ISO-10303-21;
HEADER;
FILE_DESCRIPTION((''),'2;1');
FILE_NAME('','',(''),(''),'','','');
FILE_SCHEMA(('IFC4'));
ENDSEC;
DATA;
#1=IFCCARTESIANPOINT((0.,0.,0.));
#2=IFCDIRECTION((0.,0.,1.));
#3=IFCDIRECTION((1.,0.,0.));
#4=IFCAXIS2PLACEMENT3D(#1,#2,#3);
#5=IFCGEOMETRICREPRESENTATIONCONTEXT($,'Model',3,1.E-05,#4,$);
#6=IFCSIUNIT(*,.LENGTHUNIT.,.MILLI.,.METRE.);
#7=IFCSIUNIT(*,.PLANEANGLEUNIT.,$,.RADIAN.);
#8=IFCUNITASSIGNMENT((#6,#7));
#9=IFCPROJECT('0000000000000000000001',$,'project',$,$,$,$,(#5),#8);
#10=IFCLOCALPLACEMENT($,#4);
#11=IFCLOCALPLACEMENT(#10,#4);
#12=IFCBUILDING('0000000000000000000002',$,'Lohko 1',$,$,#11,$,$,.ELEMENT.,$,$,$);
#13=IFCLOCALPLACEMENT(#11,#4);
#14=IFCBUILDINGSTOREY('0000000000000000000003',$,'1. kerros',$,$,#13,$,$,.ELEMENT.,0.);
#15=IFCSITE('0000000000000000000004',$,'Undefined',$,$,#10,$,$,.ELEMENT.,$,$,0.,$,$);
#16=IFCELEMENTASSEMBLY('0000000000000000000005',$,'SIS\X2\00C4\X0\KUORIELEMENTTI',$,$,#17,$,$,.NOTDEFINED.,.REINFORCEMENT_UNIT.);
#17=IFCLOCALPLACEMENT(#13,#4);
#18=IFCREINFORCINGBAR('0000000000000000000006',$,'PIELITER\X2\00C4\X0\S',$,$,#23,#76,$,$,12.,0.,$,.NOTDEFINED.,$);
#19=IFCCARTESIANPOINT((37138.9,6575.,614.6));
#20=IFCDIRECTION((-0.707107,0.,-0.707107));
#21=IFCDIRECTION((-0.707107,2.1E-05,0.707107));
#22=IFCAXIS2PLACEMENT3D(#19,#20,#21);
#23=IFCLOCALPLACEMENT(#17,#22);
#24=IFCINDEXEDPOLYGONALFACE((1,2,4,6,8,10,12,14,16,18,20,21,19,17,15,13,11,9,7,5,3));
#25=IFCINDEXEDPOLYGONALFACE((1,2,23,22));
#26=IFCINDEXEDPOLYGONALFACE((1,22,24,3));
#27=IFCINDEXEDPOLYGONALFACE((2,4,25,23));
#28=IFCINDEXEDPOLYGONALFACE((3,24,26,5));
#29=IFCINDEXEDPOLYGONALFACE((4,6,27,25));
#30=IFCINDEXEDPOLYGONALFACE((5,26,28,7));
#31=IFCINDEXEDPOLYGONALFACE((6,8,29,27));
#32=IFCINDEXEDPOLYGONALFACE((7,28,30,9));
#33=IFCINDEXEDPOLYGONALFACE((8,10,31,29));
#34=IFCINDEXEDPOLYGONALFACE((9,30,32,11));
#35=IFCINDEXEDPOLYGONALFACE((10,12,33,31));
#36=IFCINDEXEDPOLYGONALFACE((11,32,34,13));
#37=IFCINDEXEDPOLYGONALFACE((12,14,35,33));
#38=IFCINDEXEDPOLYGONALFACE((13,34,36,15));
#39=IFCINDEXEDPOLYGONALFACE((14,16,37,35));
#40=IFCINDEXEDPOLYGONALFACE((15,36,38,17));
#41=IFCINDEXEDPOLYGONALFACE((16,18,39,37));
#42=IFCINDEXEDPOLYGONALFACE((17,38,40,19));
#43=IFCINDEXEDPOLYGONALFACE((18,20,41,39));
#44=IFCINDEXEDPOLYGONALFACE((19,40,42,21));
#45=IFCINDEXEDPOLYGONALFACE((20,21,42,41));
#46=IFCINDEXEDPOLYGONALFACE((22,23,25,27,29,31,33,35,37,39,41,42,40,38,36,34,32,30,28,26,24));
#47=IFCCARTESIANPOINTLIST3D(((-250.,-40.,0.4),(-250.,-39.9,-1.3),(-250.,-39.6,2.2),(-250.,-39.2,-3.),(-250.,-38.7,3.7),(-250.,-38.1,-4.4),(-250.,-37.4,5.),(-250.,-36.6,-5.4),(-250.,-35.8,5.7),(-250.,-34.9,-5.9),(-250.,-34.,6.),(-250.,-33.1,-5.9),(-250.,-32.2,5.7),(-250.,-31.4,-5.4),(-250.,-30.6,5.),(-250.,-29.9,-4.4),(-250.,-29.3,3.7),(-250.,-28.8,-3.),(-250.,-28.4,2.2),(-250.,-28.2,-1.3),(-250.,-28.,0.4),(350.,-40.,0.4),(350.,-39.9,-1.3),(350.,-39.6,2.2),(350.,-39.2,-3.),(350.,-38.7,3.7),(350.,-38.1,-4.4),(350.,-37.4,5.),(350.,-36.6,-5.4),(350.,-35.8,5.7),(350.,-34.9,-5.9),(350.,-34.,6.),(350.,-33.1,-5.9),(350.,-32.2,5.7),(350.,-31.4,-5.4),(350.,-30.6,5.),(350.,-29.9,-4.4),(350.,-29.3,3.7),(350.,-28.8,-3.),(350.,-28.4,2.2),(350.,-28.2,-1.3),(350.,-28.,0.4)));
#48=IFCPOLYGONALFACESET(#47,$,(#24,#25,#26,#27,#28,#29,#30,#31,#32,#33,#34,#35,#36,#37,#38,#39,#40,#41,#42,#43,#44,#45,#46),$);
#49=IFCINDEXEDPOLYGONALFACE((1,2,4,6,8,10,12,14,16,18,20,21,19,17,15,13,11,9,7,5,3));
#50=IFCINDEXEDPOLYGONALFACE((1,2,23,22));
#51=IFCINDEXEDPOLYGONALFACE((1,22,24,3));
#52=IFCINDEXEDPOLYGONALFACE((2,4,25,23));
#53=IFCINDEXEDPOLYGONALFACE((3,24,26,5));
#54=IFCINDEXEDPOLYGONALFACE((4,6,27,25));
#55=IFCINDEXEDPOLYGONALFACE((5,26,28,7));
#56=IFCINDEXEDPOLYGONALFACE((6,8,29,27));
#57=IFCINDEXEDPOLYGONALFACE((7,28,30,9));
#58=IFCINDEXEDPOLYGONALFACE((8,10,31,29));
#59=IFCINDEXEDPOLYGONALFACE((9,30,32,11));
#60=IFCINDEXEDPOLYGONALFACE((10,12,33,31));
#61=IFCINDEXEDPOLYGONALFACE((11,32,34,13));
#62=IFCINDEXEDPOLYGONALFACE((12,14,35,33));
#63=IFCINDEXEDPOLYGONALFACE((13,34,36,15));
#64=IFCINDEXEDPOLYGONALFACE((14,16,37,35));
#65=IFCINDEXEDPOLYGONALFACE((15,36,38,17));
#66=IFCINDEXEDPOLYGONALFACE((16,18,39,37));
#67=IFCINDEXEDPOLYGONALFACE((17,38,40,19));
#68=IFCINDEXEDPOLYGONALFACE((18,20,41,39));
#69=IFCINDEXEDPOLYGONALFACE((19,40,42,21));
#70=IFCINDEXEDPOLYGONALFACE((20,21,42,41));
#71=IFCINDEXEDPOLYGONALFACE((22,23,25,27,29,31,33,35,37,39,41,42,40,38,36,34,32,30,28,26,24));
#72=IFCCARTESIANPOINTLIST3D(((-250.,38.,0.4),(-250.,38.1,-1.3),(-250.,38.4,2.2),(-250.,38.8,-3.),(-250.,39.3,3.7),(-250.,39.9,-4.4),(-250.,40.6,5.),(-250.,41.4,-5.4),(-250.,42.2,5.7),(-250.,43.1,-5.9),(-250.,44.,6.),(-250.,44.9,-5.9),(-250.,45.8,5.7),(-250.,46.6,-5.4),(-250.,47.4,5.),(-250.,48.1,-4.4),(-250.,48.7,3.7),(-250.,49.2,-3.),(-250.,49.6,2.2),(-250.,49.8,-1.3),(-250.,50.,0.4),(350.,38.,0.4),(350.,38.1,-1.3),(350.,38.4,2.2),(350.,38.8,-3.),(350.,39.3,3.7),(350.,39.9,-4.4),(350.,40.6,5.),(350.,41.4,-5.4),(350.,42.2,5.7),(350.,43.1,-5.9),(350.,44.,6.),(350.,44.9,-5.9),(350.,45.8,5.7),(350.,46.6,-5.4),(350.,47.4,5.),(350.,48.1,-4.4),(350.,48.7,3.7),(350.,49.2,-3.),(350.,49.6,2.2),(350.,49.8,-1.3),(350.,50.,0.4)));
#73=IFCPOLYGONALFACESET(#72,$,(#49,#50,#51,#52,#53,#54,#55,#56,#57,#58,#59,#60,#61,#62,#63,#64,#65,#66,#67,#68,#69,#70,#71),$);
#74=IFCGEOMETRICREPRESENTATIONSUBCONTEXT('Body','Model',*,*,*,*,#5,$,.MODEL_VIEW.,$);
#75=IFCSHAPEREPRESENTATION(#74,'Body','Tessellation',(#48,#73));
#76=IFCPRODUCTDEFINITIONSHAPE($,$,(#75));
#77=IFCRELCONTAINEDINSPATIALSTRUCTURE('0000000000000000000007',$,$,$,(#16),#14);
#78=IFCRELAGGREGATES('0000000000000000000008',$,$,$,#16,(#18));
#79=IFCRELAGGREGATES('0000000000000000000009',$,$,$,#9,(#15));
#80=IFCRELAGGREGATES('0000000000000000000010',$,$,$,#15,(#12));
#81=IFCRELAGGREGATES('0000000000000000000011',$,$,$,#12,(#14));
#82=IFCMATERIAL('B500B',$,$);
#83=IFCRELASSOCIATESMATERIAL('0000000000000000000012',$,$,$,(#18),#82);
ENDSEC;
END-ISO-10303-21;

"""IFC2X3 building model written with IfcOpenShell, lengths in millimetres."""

from ifc_helpers import new_model, entity, si_unit, frame, origin_with_axes, place, context, subcontext, project, spatial, source, transform, mapped, material, element, aggregate, save


model = new_model("IFC2X3")

# Units and contexts
model_context = context("Model", 3, precision=1e-05, world=origin_with_axes())
body_context = subcontext(model_context, "Body", "Model", "MODEL_VIEW")
ifc_project = project(units=[si_unit("LENGTHUNIT", "METRE", prefix="MILLI"), si_unit("PLANEANGLEUNIT", "RADIAN")], contexts=[model_context])

# Site, building, storey
site_placement = place(None, origin_with_axes())
site = spatial("IfcSite", under=ifc_project, at=site_placement, Name="Undefined", CompositionType="ELEMENT", RefElevation=0.0)
building_placement = place(site_placement, origin_with_axes())
building = spatial("IfcBuilding", under=site, at=building_placement, Name="Lohko 1", CompositionType="ELEMENT")
storey_placement = place(building_placement, origin_with_axes())
storey = spatial("IfcBuildingStorey", under=building, at=storey_placement, Name="1. kerros", CompositionType="ELEMENT", Elevation=0.0)

# Element assembly, reinforcing bar
assembly_placement = place(storey_placement, origin_with_axes())
assembly = element("IfcElementAssembly", 1, at=assembly_placement, inside=storey, Name="SISÄKUORIELEMENTTI", AssemblyPlace="NOTDEFINED", PredefinedType="REINFORCEMENT_UNIT")
ifc_material = material(Name="B500B")
shared_shape_1 = source(origin_with_axes(), body_context, "Body", "AdvancedSweptSolid", [
    entity("IfcSweptDiskSolid", entity("IfcTrimmedCurve", entity("IfcLine", entity("IfcCartesianPoint", [0.0, 0.0, 0.0]), entity("IfcVector", entity("IfcDirection", [1.0, 0.0, 0.0]), 1.0)), [entity("IfcParameterValue", 0.0)], [entity("IfcParameterValue", 600.0)], True, "PARAMETER"), 6.0, None, 0.0, 600.0),
])
shared_shape_2 = source(origin_with_axes(), body_context, "Body", "AdvancedSweptSolid", [
    entity("IfcSweptDiskSolid", entity("IfcTrimmedCurve", entity("IfcLine", entity("IfcCartesianPoint", [0.0, 0.0, 0.0]), entity("IfcVector", entity("IfcDirection", [1.0, 0.0, 0.0]), 1.0)), [entity("IfcParameterValue", 0.0)], [entity("IfcParameterValue", 600.0)], True, "PARAMETER"), 6.0, None, 0.0, 600.0),
])
reinforcing_bar_1_placement = place(assembly_placement, frame((37138.9, 6575.0, 614.6), z_axis=(-0.707107, 0.0, -0.707107), x_axis=(-0.707107, 0.000021, 0.707107)))
reinforcing_bar_1 = element("IfcReinforcingBar", 2, at=reinforcing_bar_1_placement, material=ifc_material, Name="PIELITERÄS", BarRole="NOTDEFINED", CrossSectionArea=0.0, NominalDiameter=12.0, context=body_context, shape_type="MappedRepresentation", body=[
    mapped(shared_shape_1, transform((-250.0, -34.0, 0.0))),
    mapped(shared_shape_2, transform((-250.0, 44.0, 0.0))),
])
aggregate(assembly, [reinforcing_bar_1])

save(model, "model.ifc")
